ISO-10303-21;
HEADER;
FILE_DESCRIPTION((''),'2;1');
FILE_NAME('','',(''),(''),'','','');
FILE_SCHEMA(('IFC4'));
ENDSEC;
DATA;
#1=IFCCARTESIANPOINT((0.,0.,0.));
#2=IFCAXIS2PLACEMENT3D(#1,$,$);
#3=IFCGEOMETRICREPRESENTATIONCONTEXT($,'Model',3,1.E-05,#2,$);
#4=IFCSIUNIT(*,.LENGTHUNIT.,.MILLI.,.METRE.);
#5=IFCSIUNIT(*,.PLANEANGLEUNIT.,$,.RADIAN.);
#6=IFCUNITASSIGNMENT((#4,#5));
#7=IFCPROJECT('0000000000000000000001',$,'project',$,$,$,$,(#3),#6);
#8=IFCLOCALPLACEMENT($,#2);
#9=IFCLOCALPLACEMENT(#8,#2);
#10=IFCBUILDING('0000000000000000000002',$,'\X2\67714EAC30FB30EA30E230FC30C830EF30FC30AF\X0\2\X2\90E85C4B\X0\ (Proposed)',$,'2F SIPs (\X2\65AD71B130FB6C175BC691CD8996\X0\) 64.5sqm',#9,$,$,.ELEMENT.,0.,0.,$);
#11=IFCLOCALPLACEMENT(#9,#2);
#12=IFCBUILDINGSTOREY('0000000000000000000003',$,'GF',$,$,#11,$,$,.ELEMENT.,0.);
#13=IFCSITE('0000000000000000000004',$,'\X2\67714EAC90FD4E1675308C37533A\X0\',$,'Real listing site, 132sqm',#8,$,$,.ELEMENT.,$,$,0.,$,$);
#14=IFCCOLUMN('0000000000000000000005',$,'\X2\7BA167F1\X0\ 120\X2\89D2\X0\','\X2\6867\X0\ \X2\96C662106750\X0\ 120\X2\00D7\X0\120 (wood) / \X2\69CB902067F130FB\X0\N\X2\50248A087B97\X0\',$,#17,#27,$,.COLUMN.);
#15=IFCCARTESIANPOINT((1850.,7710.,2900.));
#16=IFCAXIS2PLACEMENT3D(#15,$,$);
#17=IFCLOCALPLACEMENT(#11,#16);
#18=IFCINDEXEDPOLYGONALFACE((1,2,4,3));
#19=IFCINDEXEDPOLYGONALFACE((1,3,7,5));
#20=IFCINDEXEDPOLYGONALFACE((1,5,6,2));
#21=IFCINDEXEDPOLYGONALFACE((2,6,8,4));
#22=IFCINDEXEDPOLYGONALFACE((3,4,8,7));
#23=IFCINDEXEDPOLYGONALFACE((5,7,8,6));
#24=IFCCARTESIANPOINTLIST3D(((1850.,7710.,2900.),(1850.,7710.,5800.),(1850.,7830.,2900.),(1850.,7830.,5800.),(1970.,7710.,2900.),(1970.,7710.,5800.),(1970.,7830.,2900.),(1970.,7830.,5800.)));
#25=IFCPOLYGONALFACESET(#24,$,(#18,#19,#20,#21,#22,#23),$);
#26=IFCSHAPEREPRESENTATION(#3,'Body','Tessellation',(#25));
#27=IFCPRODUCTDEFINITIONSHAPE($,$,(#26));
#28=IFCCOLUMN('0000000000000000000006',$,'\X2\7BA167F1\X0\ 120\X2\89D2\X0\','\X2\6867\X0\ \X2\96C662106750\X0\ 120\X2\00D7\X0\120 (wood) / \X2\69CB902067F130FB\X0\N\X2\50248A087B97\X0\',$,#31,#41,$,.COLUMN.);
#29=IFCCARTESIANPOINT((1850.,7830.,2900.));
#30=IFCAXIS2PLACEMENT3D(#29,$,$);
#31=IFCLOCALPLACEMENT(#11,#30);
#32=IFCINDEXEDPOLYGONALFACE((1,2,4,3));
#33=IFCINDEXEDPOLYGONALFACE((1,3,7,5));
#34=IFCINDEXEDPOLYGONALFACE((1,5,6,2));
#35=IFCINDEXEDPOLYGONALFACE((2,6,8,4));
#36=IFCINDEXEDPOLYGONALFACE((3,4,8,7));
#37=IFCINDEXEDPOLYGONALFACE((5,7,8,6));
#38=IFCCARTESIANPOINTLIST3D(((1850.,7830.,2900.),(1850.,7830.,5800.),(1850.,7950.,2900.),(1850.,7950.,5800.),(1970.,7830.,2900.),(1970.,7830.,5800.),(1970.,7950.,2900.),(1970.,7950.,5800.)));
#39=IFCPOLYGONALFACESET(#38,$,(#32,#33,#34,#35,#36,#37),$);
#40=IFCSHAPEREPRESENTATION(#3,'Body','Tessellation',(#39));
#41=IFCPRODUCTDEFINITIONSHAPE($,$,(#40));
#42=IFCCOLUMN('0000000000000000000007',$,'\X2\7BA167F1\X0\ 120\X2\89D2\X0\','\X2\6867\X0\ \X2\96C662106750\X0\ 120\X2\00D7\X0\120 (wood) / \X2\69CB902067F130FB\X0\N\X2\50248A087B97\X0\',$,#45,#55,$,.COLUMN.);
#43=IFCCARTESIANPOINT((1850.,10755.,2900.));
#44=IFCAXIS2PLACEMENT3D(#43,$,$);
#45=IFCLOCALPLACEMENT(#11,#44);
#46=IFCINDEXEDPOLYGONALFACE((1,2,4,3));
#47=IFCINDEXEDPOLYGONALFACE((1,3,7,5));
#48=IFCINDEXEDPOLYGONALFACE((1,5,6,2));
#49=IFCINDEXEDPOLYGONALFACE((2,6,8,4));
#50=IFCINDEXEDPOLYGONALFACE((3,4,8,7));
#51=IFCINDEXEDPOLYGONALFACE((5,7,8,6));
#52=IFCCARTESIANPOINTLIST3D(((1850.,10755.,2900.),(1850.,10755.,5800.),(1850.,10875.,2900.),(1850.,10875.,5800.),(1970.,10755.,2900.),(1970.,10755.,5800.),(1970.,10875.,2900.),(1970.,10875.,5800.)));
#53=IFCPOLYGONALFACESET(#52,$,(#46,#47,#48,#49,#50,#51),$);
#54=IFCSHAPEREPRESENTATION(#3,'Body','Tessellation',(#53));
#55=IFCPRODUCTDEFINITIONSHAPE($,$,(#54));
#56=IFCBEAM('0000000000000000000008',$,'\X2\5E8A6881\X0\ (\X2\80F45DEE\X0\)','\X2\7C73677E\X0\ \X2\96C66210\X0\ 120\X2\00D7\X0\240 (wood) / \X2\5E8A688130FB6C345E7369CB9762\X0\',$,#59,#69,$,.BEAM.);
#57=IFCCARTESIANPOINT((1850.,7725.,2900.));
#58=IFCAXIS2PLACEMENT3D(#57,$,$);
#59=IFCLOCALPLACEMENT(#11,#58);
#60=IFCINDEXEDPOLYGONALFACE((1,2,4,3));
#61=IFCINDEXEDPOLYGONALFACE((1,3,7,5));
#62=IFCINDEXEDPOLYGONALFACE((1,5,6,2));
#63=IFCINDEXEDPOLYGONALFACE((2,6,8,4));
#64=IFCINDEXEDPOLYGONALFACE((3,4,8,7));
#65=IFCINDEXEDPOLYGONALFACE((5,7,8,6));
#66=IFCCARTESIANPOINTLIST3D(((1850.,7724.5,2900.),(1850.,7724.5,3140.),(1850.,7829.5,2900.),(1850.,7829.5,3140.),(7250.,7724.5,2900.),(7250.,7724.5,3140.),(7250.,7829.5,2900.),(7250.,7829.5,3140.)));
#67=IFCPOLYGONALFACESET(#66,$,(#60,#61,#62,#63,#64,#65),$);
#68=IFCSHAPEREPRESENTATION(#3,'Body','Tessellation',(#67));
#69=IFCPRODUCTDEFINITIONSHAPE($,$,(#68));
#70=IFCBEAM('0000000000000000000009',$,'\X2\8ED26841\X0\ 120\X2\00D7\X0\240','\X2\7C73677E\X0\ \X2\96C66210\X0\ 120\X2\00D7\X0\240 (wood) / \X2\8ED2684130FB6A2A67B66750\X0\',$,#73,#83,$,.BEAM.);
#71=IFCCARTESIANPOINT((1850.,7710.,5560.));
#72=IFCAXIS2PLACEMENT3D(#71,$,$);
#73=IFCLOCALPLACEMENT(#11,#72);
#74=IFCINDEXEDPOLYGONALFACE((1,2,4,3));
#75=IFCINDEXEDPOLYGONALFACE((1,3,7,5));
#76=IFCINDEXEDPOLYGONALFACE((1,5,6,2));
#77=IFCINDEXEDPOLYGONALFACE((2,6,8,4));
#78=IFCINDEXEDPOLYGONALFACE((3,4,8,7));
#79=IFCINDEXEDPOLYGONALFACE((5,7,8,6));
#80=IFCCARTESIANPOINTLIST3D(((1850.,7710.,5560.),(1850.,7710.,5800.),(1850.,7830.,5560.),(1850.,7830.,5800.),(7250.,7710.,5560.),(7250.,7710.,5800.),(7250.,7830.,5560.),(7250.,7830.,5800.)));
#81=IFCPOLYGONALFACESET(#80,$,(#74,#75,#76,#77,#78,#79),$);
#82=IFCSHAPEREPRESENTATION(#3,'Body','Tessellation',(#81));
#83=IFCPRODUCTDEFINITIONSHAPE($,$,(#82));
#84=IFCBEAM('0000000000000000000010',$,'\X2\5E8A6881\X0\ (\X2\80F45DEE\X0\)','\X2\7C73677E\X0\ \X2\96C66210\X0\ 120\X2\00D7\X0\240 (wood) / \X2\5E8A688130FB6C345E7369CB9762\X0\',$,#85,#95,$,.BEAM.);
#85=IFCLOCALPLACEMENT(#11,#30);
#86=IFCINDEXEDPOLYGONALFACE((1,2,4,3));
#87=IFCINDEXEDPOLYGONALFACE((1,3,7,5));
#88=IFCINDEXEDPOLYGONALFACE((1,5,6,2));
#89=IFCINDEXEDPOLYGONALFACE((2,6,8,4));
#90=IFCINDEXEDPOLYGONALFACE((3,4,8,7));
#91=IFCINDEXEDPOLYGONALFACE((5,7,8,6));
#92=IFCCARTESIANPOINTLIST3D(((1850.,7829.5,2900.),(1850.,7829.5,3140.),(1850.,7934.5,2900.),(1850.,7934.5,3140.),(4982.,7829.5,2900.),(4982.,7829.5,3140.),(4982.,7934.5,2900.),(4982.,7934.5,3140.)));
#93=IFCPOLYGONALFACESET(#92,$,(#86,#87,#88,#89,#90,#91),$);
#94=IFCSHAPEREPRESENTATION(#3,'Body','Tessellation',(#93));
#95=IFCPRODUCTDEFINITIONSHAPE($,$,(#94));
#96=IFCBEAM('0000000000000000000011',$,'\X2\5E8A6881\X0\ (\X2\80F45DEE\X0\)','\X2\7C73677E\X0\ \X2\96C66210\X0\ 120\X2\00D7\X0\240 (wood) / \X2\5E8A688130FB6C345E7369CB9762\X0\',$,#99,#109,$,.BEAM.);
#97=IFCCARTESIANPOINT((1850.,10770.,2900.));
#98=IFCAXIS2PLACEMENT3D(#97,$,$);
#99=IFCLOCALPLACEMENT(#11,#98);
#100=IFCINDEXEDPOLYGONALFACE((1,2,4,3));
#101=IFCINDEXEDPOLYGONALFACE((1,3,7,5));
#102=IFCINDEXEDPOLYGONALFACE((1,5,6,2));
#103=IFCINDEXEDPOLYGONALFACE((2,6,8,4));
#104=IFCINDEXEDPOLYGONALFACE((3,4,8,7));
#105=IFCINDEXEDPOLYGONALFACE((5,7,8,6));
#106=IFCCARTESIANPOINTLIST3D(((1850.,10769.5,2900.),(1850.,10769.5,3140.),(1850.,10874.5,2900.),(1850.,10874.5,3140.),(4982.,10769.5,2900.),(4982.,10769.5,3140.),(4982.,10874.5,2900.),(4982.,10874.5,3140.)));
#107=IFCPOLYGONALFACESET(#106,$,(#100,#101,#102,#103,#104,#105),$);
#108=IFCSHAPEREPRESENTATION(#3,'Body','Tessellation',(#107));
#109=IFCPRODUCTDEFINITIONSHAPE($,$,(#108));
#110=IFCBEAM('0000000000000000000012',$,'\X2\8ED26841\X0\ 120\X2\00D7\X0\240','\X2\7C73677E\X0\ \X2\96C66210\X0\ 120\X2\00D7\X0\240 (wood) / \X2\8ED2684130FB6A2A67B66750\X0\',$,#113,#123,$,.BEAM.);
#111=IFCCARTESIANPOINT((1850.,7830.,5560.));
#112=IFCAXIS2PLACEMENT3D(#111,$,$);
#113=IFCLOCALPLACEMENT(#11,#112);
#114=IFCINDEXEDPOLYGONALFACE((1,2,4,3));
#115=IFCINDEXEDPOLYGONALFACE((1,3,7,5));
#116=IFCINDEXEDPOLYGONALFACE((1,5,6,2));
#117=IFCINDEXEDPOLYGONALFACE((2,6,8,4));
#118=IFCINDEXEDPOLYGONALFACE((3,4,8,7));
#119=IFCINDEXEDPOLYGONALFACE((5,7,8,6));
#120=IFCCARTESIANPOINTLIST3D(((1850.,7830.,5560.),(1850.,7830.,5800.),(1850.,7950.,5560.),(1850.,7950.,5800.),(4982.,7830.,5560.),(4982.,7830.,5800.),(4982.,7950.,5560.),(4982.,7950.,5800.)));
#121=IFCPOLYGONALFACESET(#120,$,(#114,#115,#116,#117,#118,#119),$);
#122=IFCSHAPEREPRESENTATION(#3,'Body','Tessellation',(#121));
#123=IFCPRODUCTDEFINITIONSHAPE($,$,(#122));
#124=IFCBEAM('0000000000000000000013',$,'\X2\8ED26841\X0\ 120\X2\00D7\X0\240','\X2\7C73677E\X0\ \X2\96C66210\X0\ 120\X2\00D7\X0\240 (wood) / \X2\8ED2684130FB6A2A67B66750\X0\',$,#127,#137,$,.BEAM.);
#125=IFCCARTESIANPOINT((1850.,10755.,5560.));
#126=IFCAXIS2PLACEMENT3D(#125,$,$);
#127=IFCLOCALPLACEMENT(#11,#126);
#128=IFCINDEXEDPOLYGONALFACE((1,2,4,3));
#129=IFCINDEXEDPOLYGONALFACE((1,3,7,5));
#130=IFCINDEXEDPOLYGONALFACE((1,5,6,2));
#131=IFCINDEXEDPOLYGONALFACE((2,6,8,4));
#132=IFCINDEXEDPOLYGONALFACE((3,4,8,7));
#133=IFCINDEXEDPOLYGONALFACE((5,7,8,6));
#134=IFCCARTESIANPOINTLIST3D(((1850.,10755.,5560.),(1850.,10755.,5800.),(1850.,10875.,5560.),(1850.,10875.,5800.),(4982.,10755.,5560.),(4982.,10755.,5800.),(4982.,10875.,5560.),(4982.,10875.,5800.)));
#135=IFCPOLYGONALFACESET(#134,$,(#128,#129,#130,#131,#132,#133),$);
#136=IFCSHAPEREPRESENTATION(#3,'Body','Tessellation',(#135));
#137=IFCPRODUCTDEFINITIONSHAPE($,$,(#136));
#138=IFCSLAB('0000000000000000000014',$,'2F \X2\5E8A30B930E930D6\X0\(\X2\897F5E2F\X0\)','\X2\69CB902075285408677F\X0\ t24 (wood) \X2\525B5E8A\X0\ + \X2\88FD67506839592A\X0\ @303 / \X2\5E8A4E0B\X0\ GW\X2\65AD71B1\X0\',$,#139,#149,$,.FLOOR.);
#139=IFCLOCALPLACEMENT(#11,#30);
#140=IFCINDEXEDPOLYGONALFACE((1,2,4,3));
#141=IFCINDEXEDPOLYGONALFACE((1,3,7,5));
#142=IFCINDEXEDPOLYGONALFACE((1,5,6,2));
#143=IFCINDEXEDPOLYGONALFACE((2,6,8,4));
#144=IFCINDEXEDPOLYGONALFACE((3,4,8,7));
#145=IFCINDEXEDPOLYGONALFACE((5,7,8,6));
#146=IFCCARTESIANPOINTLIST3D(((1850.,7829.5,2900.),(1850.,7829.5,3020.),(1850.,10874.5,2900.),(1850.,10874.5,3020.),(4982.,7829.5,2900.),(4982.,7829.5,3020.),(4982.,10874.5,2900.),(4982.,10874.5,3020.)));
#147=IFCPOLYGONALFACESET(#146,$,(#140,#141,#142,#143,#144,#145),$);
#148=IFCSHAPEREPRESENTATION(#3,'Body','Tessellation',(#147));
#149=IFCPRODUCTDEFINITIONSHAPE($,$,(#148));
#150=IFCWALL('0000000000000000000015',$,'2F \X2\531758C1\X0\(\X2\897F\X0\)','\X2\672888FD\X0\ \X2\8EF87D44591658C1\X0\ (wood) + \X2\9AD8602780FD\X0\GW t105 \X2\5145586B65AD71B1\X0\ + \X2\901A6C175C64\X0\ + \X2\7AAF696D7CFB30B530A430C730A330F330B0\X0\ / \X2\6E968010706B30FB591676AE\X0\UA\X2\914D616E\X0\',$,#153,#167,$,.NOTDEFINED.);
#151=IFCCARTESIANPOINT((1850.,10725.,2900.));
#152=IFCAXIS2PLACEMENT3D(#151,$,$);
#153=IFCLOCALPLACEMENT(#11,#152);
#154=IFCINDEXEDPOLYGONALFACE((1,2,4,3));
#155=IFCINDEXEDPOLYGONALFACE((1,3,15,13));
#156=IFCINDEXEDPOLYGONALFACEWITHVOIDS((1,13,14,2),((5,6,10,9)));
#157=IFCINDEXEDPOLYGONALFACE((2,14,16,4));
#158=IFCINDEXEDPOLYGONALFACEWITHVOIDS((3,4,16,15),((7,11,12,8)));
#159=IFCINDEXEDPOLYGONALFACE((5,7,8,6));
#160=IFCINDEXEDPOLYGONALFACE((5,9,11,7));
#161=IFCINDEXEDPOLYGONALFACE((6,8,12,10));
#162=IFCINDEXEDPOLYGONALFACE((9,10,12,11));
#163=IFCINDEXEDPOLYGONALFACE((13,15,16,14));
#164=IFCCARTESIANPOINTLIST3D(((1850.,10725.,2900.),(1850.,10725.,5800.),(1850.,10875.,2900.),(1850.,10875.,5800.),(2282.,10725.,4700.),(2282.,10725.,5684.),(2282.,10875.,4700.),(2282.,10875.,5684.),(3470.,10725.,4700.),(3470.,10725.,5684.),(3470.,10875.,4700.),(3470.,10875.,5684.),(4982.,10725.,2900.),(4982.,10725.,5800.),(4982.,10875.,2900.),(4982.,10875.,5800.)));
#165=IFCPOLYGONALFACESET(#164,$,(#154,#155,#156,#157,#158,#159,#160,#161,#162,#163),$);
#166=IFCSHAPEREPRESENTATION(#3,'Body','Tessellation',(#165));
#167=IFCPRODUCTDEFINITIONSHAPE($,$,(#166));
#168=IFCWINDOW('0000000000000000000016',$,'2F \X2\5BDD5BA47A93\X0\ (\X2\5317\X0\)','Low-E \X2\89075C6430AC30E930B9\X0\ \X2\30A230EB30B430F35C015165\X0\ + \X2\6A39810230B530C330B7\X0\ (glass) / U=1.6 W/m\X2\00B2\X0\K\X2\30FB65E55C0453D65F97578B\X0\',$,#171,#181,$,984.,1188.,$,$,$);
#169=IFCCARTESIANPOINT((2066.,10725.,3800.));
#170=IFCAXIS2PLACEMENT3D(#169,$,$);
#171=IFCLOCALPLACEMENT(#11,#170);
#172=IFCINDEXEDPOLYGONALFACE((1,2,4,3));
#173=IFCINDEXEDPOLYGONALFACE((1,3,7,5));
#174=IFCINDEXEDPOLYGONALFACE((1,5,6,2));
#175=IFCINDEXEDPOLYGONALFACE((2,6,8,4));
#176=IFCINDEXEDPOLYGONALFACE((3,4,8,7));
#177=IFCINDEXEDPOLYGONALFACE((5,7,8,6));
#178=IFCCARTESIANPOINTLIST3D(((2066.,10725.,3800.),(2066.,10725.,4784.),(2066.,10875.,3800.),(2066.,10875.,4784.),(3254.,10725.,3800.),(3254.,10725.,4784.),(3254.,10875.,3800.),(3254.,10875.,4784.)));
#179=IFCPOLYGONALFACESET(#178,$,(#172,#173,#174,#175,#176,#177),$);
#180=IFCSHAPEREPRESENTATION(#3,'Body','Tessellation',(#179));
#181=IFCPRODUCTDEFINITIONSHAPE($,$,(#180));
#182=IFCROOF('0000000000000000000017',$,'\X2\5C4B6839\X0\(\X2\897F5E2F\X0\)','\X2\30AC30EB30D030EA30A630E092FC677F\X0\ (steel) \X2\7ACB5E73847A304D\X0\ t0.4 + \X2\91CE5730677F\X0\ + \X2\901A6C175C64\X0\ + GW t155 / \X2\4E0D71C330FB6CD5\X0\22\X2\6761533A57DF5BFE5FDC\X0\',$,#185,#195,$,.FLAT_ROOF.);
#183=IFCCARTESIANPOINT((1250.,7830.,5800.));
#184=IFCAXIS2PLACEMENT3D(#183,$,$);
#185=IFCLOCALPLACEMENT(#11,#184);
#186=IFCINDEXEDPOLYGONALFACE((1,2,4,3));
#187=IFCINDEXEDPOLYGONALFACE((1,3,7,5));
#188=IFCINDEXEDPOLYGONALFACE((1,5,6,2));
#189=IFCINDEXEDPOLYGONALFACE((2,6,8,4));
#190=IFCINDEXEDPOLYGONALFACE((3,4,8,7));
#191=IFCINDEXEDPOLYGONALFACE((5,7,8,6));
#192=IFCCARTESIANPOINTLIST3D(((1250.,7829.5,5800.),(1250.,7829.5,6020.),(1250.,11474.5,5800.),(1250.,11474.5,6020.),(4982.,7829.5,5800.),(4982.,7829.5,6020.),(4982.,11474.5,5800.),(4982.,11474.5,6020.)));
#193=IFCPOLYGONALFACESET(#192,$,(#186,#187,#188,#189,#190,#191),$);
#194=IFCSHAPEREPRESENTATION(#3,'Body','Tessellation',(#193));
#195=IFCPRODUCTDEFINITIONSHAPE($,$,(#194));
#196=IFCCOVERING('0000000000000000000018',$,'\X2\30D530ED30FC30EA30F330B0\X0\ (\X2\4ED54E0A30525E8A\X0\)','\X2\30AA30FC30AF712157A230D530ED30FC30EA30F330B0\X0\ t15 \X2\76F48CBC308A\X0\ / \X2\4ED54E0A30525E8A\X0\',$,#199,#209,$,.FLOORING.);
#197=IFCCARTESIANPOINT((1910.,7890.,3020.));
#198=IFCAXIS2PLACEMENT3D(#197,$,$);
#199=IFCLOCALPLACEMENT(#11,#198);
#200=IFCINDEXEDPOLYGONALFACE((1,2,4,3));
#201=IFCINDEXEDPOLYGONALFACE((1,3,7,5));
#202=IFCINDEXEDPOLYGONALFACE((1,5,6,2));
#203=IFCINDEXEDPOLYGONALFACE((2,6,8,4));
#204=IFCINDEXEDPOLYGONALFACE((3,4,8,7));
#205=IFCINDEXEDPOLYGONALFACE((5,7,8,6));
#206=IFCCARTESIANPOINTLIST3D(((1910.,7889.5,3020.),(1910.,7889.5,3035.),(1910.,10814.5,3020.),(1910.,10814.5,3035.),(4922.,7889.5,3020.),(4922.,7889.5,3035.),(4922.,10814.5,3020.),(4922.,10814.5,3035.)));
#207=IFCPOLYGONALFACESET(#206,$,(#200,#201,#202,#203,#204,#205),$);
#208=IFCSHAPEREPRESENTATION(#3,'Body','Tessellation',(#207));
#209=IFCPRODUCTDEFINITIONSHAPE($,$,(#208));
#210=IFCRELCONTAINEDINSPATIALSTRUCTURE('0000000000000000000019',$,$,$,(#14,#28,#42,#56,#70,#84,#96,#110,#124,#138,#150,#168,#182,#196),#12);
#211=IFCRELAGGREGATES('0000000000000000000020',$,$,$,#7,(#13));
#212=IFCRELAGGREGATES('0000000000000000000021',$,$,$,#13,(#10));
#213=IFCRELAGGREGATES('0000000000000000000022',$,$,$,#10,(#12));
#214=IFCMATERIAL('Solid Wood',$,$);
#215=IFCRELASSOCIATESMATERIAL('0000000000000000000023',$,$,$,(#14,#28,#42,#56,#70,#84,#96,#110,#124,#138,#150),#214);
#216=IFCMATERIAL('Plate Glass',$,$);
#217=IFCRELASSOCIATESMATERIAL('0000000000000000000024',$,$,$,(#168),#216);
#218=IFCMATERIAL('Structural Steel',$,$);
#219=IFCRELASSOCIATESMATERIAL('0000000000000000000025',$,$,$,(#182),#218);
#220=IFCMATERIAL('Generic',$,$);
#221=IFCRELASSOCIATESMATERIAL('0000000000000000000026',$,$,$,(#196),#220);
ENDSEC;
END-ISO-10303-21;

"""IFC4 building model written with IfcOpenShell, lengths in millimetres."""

from ifc_helpers import new_model, si_unit, frame, frame_2d, origin, place, context, project, spatial, rectangle, extrude, material, element, fill, save


model = new_model("IFC4")

# Units and contexts
model_context = context("Model", 3, precision=1e-05, world=origin())
ifc_project = project(units=[si_unit("LENGTHUNIT", "METRE", prefix="MILLI"), si_unit("PLANEANGLEUNIT", "RADIAN")], contexts=[model_context])

# Site, building, storey
site_placement = place(None, origin())
site = spatial("IfcSite", under=ifc_project, at=site_placement, Name="東京都世田谷区", ObjectType="Real listing site, 132sqm", CompositionType="ELEMENT", RefElevation=0.0)
building_placement = place(site_placement, origin())
building = spatial("IfcBuilding", under=site, at=building_placement, Name="東京・リモートワーク2部屋 (Proposed)", ObjectType="2F SIPs (断熱・気密重視) 64.5sqm", CompositionType="ELEMENT", ElevationOfRefHeight=0.0, ElevationOfTerrain=0.0)
storey_placement = place(building_placement, origin())
storey = spatial("IfcBuildingStorey", under=building, at=storey_placement, Name="GF", CompositionType="ELEMENT", Elevation=0.0)

# Columns
ifc_material_1 = material(Name="Solid Wood")
column_1_placement = place(storey_placement, frame((1850.0, 7710.0, 2900.0)))
element("IfcColumn", 1, at=column_1_placement, inside=storey, material=ifc_material_1, Name="管柱 120角", Description="桧 集成材 120×120 (wood) / 構造柱・N値計算", PredefinedType="COLUMN", context=model_context, shape_type="SweptSolid", body=[
    extrude(rectangle(XDim=120.0, YDim=120.0, at=frame_2d((60.0, 60.0))), frame((1850.0, 7710.0, 2900.0)), (0.0, 0.0, 1.0), 2900.0),
])
column_2_placement = place(storey_placement, frame((1850.0, 7830.0, 2900.0)))
element("IfcColumn", 2, at=column_2_placement, inside=storey, material=ifc_material_1, Name="管柱 120角", Description="桧 集成材 120×120 (wood) / 構造柱・N値計算", PredefinedType="COLUMN", context=model_context, shape_type="SweptSolid", body=[
    extrude(rectangle(XDim=120.0, YDim=120.0, at=frame_2d((60.0, 60.0))), frame((1850.0, 7830.0, 2900.0)), (0.0, 0.0, 1.0), 2900.0),
])
column_3_placement = place(storey_placement, frame((1850.0, 10755.0, 2900.0)))
element("IfcColumn", 3, at=column_3_placement, inside=storey, material=ifc_material_1, Name="管柱 120角", Description="桧 集成材 120×120 (wood) / 構造柱・N値計算", PredefinedType="COLUMN", context=model_context, shape_type="SweptSolid", body=[
    extrude(rectangle(XDim=120.0, YDim=120.0, at=frame_2d((60.0, 60.0))), frame((1850.0, 10755.0, 2900.0)), (0.0, 0.0, 1.0), 2900.0),
])

# Beams
beam_1_placement = place(storey_placement, frame((1850.0, 7725.0, 2900.0)))
element("IfcBeam", 4, at=beam_1_placement, inside=storey, material=ifc_material_1, Name="床梁 (胴差)", Description="米松 集成 120×240 (wood) / 床梁・水平構面", PredefinedType="BEAM", context=model_context, shape_type="SweptSolid", body=[
    extrude(rectangle(XDim=5400.0, YDim=105.0, at=frame_2d((2700.0, 52.0))), frame((1850.0, 7725.0, 2900.0)), (0.0, 0.0, 1.0), 240.0),
])
beam_2_placement = place(storey_placement, frame((1850.0, 7710.0, 5560.0)))
element("IfcBeam", 5, at=beam_2_placement, inside=storey, material=ifc_material_1, Name="軒桁 120×240", Description="米松 集成 120×240 (wood) / 軒桁・横架材", PredefinedType="BEAM", context=model_context, shape_type="SweptSolid", body=[
    extrude(rectangle(XDim=5400.0, YDim=120.0, at=frame_2d((2700.0, 60.0))), frame((1850.0, 7710.0, 5560.0)), (0.0, 0.0, 1.0), 240.0),
])
beam_3_placement = place(storey_placement, frame((1850.0, 7830.0, 2900.0)))
element("IfcBeam", 6, at=beam_3_placement, inside=storey, material=ifc_material_1, Name="床梁 (胴差)", Description="米松 集成 120×240 (wood) / 床梁・水平構面", PredefinedType="BEAM", context=model_context, shape_type="SweptSolid", body=[
    extrude(rectangle(XDim=3132.0, YDim=105.0, at=frame_2d((1566.0, 52.0))), frame((1850.0, 7830.0, 2900.0)), (0.0, 0.0, 1.0), 240.0),
])
beam_4_placement = place(storey_placement, frame((1850.0, 10770.0, 2900.0)))
element("IfcBeam", 7, at=beam_4_placement, inside=storey, material=ifc_material_1, Name="床梁 (胴差)", Description="米松 集成 120×240 (wood) / 床梁・水平構面", PredefinedType="BEAM", context=model_context, shape_type="SweptSolid", body=[
    extrude(rectangle(XDim=3132.0, YDim=105.0, at=frame_2d((1566.0, 52.0))), frame((1850.0, 10770.0, 2900.0)), (0.0, 0.0, 1.0), 240.0),
])
beam_5_placement = place(storey_placement, frame((1850.0, 7830.0, 5560.0)))
element("IfcBeam", 8, at=beam_5_placement, inside=storey, material=ifc_material_1, Name="軒桁 120×240", Description="米松 集成 120×240 (wood) / 軒桁・横架材", PredefinedType="BEAM", context=model_context, shape_type="SweptSolid", body=[
    extrude(rectangle(XDim=3132.0, YDim=120.0, at=frame_2d((1566.0, 60.0))), frame((1850.0, 7830.0, 5560.0)), (0.0, 0.0, 1.0), 240.0),
])
beam_6_placement = place(storey_placement, frame((1850.0, 10755.0, 5560.0)))
element("IfcBeam", 9, at=beam_6_placement, inside=storey, material=ifc_material_1, Name="軒桁 120×240", Description="米松 集成 120×240 (wood) / 軒桁・横架材", PredefinedType="BEAM", context=model_context, shape_type="SweptSolid", body=[
    extrude(rectangle(XDim=3132.0, YDim=120.0, at=frame_2d((1566.0, 60.0))), frame((1850.0, 10755.0, 5560.0)), (0.0, 0.0, 1.0), 240.0),
])

# Slab
slab_placement = place(storey_placement, frame((1850.0, 7830.0, 2900.0)))
element("IfcSlab", 10, at=slab_placement, inside=storey, material=ifc_material_1, Name="2F 床スラブ(西帯)", Description="構造用合板 t24 (wood) 剛床 + 製材根太 @303 / 床下 GW断熱", PredefinedType="FLOOR", context=model_context, shape_type="SweptSolid", body=[
    extrude(rectangle(XDim=3132.0, YDim=3045.0, at=frame_2d((1566.0, 1522.0))), frame((1850.0, 7830.0, 2900.0)), (0.0, 0.0, 1.0), 120.0),
])

# Wall, opening, window
wall_1_placement = place(storey_placement, frame((1850.0, 10725.0, 2900.0)))
wall_1 = element("IfcWall", 11, at=wall_1_placement, inside=storey, material=ifc_material_1, Name="2F 北壁(西)", Description="木製 軸組外壁 (wood) + 高性能GW t105 充填断熱 + 通気層 + 窯業系サイディング / 準耐火・外皮UA配慮", PredefinedType="NOTDEFINED", context=model_context, shape_type="SweptSolid", body=[
    extrude(rectangle(XDim=3132.0, YDim=150.0, at=frame_2d((1566.0, 75.0))), frame((1850.0, 10725.0, 2900.0)), (0.0, 0.0, 1.0), 2900.0),
])
opening_placement = place(storey_placement, frame((2066.0, 10725.0, 3800.0)))
opening = element("IfcOpeningElement", 12, at=opening_placement, cuts=wall_1, PredefinedType="NOTDEFINED", context=model_context, shape_type="SweptSolid", body=[
    extrude(rectangle(XDim=1188.0, YDim=150.0, at=frame_2d((594.0, 75.0))), frame((2066.0, 10725.0, 3800.0)), (0.0, 0.0, 1.0), 984.0),
])
ifc_material_2 = material(Name="Plate Glass")
window_placement = place(storey_placement, frame((2066.0, 10725.0, 3800.0)))
window = element("IfcWindow", 13, at=window_placement, inside=storey, material=ifc_material_2, Name="2F 寝室窓 (北)", Description="Low-E 複層ガラス アルゴン封入 + 樹脂サッシ (glass) / U=1.6 W/m²K・日射取得型", OverallHeight=984.0, OverallWidth=1188.0, context=model_context, shape_type="SweptSolid", body=[
    extrude(rectangle(XDim=1188.0, YDim=150.0, at=frame_2d((594.0, 75.0))), frame((2066.0, 10725.0, 3800.0)), (0.0, 0.0, 1.0), 984.0),
])
fill(opening, window)

# Roof
ifc_material_3 = material(Name="Structural Steel")
for number, where, name in (
    (14, (1250.0, 7830.0, 5800.0), "屋根(西帯)"),
):
    element("IfcRoof", number, at=place(storey_placement, frame(where)), inside=storey, material=ifc_material_3, Name=name, Description="ガルバリウム鋼板 (steel) 立平葺き t0.4 + 野地板 + 通気層 + GW t155 / 不燃・法22条区域対応", PredefinedType="FLAT_ROOF", context=model_context, shape_type="SweptSolid", body=[
        extrude(rectangle(XDim=3732.0, YDim=3645.0, at=frame_2d((1866.0, 1822.0))), frame((1250.0, 7830.0, 5800.0)), (0.0, 0.0, 1.0), 220.0),
    ])

# Covering
ifc_material_4 = material(Name="Generic")
covering_placement = place(storey_placement, frame((1910.0, 7890.0, 3020.0)))
element("IfcCovering", 15, at=covering_placement, inside=storey, material=ifc_material_4, Name="フローリング (仕上げ床)", Description="オーク無垢フローリング t15 直貼り / 仕上げ床", PredefinedType="FLOORING", context=model_context, shape_type="SweptSolid", body=[
    extrude(rectangle(XDim=3012.0, YDim=2925.0, at=frame_2d((1506.0, 1462.0))), frame((1910.0, 7890.0, 3020.0)), (0.0, 0.0, 1.0), 15.0),
])

save(model, "model.ifc")
